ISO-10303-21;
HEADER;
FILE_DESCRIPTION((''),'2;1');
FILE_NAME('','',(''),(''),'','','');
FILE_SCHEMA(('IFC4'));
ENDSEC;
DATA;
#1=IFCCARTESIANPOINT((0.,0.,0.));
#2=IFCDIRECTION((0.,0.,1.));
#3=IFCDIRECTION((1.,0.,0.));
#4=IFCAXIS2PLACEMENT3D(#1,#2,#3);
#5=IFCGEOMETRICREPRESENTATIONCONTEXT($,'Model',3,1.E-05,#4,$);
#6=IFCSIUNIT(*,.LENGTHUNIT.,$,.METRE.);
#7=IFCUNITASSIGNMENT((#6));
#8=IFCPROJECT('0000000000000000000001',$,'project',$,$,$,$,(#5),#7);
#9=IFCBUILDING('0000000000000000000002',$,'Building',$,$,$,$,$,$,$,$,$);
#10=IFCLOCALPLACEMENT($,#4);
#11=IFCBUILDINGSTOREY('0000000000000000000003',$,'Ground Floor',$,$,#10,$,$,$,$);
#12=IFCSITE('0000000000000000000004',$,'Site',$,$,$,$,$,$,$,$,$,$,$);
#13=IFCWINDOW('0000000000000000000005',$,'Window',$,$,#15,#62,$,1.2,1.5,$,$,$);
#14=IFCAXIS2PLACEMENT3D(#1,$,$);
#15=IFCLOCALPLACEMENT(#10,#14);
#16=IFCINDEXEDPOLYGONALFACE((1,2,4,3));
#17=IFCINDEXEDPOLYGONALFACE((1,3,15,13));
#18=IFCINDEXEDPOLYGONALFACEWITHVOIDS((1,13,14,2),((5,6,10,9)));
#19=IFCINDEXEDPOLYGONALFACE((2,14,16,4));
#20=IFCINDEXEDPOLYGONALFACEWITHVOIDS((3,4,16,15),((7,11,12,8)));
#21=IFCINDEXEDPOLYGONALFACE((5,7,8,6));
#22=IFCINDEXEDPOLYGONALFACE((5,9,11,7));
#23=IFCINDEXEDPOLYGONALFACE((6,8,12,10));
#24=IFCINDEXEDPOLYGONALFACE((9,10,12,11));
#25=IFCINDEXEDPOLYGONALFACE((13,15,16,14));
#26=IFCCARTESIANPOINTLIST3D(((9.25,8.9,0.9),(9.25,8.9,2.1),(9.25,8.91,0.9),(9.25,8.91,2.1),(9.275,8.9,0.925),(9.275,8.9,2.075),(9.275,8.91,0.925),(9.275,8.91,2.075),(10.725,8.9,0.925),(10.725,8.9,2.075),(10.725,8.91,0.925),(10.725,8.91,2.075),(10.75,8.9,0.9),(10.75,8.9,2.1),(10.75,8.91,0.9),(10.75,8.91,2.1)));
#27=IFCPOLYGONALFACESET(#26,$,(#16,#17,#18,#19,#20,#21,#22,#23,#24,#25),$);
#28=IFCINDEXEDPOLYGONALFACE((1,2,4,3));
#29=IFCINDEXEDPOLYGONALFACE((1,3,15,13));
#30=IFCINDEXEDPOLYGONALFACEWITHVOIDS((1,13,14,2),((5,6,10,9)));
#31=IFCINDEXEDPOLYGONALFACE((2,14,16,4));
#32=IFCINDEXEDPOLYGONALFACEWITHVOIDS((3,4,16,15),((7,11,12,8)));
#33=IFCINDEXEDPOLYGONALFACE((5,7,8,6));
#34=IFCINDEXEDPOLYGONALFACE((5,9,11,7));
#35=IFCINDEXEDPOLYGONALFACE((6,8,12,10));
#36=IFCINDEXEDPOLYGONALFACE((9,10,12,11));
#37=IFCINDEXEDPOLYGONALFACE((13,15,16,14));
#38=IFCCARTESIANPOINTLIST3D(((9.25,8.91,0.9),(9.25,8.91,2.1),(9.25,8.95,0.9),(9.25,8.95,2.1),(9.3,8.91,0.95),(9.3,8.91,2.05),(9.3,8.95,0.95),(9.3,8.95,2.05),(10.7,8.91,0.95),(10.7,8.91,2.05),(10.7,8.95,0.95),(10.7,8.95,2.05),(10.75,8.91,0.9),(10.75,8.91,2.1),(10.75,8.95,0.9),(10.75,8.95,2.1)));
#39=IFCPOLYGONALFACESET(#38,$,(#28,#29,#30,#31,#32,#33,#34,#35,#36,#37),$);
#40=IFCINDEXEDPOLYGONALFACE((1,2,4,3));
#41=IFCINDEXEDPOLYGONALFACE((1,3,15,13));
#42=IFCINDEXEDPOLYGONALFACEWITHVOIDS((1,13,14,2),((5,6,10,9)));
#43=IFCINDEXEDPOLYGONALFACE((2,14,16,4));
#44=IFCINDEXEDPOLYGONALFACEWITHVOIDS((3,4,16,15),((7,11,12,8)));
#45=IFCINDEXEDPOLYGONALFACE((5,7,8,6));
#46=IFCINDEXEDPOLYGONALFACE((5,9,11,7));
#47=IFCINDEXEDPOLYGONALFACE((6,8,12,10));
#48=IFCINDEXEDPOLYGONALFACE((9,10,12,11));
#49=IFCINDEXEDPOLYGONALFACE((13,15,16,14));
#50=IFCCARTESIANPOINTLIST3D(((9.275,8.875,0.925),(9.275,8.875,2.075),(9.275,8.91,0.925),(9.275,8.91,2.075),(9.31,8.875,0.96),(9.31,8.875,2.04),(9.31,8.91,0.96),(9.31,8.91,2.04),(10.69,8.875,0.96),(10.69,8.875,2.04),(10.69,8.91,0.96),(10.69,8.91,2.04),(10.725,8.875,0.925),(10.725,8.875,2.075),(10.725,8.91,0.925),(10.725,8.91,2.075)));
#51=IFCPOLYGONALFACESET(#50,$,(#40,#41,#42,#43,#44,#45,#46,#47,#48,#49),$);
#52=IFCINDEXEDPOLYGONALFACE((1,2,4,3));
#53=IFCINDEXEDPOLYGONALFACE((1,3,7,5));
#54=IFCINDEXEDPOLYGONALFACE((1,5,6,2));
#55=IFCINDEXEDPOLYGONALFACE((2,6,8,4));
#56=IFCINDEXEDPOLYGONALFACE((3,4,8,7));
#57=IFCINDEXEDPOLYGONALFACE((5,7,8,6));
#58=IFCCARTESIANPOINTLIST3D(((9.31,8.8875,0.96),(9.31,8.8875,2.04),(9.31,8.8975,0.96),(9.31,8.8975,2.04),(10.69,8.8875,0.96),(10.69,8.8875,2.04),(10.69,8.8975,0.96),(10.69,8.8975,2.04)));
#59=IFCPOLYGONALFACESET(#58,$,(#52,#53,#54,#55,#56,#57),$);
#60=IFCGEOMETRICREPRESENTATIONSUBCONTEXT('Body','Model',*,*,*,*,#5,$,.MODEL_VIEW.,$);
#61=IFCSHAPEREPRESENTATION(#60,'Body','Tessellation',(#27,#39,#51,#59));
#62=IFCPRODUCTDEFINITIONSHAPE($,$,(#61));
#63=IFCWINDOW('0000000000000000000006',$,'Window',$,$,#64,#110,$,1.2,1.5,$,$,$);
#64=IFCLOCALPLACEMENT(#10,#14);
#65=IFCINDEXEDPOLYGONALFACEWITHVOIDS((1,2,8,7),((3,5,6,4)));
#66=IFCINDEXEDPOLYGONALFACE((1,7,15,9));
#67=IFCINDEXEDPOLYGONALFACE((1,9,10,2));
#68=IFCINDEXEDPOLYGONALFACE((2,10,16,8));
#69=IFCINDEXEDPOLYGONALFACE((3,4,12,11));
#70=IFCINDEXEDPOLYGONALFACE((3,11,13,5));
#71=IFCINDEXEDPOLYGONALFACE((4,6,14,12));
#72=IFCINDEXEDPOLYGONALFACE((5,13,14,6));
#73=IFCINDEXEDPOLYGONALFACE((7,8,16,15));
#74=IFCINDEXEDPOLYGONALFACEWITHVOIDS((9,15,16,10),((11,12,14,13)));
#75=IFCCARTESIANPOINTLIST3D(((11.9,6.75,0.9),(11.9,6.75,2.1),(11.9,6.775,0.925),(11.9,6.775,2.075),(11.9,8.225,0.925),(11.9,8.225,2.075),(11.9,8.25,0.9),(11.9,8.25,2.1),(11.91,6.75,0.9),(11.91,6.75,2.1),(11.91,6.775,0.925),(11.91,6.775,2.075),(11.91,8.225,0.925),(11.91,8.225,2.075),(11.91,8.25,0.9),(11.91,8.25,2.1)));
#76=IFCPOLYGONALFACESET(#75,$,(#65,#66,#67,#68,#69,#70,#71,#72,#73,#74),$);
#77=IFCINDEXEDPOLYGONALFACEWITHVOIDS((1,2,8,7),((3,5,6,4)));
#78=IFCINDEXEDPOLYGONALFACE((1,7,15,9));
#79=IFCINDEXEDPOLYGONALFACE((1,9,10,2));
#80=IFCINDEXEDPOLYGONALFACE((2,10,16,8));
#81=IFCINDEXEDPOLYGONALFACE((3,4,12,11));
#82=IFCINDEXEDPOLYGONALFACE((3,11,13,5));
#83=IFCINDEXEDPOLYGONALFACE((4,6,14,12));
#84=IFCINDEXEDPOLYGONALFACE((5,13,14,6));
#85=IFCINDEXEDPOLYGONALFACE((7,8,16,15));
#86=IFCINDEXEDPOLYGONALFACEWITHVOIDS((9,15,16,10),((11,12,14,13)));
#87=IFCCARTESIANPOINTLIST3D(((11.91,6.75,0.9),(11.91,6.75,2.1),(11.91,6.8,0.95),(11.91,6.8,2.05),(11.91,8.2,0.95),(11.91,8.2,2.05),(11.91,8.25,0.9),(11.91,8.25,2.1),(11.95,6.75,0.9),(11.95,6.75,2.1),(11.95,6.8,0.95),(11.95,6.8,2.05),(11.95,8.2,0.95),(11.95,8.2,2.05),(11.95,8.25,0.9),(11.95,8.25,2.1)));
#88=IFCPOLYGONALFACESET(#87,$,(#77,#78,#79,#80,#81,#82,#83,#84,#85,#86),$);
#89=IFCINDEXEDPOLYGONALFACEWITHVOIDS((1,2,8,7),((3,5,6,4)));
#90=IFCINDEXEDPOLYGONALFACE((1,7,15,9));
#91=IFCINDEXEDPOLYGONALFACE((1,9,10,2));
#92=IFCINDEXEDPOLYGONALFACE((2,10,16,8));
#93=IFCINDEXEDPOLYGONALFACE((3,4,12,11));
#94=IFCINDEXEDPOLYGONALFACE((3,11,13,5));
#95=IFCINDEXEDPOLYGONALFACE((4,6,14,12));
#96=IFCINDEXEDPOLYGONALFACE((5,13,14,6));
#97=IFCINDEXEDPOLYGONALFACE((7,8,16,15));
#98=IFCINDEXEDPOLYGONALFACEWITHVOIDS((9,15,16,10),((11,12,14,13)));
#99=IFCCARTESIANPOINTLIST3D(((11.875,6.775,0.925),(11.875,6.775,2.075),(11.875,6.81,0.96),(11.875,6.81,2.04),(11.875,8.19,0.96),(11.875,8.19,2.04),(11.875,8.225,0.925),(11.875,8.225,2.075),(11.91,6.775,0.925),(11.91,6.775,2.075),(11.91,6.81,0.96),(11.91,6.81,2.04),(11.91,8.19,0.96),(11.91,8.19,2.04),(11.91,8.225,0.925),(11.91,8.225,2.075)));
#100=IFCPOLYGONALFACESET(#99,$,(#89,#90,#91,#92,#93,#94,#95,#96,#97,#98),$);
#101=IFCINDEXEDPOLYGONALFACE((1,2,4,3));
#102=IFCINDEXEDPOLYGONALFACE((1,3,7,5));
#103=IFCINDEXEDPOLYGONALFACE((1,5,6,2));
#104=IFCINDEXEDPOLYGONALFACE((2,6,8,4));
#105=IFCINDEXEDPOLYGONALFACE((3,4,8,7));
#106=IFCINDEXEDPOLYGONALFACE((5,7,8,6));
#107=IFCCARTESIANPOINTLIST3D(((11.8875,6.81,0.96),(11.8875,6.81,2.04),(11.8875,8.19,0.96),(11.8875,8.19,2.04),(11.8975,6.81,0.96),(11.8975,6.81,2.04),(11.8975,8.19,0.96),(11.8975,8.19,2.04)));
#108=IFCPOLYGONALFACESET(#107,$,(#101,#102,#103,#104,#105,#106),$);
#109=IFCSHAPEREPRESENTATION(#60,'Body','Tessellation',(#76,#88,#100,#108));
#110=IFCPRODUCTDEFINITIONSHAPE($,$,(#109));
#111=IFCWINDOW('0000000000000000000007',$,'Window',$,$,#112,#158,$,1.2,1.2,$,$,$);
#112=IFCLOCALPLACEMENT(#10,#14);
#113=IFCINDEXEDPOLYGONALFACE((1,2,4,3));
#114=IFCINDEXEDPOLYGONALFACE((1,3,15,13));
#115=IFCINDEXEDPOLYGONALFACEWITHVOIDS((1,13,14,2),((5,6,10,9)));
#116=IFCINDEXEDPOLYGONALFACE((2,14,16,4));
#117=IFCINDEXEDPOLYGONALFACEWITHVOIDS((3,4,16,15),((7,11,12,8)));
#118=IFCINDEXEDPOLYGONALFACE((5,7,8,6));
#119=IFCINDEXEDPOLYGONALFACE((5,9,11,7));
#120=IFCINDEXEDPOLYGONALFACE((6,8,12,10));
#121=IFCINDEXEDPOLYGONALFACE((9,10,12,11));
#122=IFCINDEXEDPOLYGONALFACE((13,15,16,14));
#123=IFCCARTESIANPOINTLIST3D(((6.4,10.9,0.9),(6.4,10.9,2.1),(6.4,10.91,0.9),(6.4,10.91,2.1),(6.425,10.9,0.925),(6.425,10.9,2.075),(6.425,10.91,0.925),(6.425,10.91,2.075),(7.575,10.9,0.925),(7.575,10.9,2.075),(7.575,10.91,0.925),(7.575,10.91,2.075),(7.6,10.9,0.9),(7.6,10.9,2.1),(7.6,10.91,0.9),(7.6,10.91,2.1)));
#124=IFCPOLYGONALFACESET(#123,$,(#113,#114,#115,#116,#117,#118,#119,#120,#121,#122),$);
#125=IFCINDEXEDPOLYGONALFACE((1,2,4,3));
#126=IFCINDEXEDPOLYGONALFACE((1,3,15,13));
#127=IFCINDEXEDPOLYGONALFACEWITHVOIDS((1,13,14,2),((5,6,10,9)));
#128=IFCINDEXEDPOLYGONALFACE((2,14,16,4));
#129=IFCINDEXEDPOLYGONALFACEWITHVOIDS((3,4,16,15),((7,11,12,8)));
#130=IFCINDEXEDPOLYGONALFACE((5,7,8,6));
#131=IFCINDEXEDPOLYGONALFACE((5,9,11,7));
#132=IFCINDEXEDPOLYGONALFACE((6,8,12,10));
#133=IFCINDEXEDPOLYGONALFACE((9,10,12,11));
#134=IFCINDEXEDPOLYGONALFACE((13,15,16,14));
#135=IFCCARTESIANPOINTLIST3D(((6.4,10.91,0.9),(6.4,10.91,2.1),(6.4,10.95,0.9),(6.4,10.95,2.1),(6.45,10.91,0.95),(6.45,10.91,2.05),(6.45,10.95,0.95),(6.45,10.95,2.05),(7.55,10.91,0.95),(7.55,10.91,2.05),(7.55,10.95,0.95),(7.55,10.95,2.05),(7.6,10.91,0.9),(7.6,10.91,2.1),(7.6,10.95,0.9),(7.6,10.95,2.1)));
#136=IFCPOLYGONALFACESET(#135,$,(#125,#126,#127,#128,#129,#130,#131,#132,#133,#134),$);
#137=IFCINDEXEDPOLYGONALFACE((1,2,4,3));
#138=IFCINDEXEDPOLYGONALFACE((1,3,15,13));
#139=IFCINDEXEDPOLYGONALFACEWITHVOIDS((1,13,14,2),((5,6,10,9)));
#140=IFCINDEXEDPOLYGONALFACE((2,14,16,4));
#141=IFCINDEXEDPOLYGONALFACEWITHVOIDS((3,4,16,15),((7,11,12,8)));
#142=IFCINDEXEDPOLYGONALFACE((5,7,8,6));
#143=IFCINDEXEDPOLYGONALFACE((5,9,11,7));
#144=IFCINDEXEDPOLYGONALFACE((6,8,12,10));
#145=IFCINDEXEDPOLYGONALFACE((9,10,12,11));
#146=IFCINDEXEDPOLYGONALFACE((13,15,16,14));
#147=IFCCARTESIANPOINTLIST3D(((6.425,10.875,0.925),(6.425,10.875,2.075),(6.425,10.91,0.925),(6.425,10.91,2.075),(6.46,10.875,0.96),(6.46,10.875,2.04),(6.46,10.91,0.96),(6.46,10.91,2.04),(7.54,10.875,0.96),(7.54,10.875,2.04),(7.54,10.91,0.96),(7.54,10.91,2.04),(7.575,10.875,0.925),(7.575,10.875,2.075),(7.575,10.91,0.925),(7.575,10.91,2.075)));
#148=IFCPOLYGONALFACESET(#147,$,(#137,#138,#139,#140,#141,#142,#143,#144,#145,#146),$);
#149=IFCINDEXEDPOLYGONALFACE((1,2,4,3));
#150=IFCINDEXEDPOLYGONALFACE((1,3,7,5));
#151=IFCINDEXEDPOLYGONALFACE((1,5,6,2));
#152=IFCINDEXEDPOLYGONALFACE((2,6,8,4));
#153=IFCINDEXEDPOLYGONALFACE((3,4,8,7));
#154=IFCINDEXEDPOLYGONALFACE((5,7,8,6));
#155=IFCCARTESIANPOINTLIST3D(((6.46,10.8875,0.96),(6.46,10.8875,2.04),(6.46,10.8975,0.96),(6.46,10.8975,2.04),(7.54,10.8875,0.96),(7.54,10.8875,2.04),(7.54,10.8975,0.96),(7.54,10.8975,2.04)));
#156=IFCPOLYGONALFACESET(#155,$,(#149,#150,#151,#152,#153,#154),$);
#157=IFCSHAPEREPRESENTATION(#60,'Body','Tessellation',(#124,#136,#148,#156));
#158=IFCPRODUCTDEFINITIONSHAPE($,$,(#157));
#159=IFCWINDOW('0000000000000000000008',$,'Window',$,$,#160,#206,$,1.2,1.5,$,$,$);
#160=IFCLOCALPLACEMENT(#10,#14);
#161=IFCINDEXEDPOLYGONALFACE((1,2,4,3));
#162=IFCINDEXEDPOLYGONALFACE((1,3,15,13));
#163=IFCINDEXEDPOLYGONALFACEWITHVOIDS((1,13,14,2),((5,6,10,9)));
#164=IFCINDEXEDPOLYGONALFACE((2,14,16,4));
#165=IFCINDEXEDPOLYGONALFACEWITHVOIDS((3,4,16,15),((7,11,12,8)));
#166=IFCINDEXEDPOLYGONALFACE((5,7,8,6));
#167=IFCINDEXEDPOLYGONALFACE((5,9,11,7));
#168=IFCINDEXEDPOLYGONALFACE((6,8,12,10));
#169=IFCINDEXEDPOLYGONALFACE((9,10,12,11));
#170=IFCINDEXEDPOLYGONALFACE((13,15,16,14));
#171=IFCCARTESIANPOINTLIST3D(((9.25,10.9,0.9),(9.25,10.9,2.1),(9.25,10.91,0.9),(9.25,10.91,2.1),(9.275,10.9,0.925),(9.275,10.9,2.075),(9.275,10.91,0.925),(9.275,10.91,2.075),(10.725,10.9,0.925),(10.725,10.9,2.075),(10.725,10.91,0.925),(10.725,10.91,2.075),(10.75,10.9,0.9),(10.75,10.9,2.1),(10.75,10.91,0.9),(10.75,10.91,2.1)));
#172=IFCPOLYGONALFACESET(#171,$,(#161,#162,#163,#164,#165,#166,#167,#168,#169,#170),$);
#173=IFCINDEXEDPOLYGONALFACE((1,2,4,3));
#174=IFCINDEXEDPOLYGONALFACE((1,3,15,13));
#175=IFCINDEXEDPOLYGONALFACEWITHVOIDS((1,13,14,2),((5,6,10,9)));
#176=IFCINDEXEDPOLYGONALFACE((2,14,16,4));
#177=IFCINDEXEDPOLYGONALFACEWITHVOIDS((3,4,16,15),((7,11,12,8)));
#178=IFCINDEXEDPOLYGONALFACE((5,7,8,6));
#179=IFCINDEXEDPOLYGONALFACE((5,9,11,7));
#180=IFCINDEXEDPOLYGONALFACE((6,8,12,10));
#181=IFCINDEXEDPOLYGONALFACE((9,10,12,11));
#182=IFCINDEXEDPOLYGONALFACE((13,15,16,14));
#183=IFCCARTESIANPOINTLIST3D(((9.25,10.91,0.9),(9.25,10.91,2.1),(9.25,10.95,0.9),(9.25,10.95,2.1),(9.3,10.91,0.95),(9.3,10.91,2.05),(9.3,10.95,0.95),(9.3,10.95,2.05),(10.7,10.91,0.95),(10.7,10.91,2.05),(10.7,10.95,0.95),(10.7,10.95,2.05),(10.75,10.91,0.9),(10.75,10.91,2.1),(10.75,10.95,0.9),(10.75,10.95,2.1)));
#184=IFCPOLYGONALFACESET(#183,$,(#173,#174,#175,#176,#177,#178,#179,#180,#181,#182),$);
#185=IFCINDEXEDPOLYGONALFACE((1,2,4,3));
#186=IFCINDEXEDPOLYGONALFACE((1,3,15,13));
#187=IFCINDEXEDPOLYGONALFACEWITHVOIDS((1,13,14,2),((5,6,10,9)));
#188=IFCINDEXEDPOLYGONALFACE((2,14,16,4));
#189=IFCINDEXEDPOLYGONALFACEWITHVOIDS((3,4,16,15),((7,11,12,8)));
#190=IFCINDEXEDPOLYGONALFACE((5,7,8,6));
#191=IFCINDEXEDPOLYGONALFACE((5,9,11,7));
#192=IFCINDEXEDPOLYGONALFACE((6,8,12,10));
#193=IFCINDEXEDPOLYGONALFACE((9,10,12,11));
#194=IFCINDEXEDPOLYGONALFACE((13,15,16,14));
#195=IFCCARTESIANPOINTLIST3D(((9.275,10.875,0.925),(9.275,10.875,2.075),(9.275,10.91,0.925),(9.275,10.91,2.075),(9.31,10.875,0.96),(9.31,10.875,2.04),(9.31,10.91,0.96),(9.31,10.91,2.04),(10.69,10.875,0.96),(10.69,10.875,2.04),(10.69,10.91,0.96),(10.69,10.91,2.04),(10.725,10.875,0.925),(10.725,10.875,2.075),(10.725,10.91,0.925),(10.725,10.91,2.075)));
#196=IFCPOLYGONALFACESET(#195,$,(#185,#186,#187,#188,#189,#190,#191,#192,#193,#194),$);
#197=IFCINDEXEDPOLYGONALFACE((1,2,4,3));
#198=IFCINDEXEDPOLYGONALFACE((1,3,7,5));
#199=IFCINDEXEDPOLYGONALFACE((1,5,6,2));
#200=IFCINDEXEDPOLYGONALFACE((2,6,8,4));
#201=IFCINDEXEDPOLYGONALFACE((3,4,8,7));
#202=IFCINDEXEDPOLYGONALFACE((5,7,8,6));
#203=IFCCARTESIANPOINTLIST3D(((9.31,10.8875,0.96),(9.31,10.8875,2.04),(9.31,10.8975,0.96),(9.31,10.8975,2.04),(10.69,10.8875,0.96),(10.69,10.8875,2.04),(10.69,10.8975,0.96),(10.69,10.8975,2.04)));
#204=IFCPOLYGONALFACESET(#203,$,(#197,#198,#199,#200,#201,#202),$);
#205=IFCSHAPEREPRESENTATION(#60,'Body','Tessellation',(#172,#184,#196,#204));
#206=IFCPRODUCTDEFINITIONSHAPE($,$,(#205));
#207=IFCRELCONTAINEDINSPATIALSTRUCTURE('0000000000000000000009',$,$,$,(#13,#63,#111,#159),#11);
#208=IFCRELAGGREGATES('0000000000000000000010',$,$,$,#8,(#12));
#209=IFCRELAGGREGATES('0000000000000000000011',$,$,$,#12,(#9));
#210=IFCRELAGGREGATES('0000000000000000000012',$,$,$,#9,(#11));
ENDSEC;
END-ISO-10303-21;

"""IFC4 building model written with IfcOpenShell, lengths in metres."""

from ifc_helpers import new_model, si_unit, frame, origin_with_axes, place, context, subcontext, project, spatial, line, indexed_curve, outline, extrude, element, save


model = new_model("IFC4")

# Units and contexts
model_context = context("Model", 3, precision=1e-05, world=origin_with_axes())
body_context = subcontext(model_context, "Body", "Model", "MODEL_VIEW")
ifc_project = project(units=[si_unit("LENGTHUNIT", "METRE")], contexts=[model_context])

# Site, building, storey
site = spatial("IfcSite", under=ifc_project, Name="Site")
building = spatial("IfcBuilding", under=site, Name="Building")
storey_placement = place(None, origin_with_axes())
storey = spatial("IfcBuildingStorey", under=building, at=storey_placement, Name="Ground Floor")

# Windows
for number, where, z_axis, x_axis, name in (
    (1, (10.75, 9.0, 0.9), (0.0, 0.0, 1.0), (-1.0, 0.0, 0.0), "Window"),
    (2, (12.0, 6.75, 0.9), (0.0, 0.0, 1.0), (0.0, 1.0, 0.0), "Window"),
):
    element("IfcWindow", number, at=place(storey_placement, frame(where, z_axis=z_axis, x_axis=x_axis)), inside=storey, Name=name, OverallHeight=1.2, OverallWidth=1.5, context=body_context, shape_type="SweptSolid", body=[
        extrude(outline(indexed_curve([(0.0, 0.0), (1.5, 0.0), (1.5, 1.2), (0.0, 1.2)], segments=[line(1, 2, 3, 4, 1)]), holes=[indexed_curve([(0.025, 0.025), (1.475, 0.025), (1.475, 1.175), (0.025, 1.175)], segments=[line(1, 2, 3, 4, 1)])]), frame((0.0, 0.09, 0.0), z_axis=(0.0, -1.0, 0.0), x_axis=(1.0, 0.0, 0.0)), (0.0, 0.0, -1.0), 0.01),
        extrude(outline(indexed_curve([(0.0, 0.0), (1.5, 0.0), (1.5, 1.2), (0.0, 1.2)], segments=[line(1, 2, 3, 4, 1)]), holes=[indexed_curve([(0.05, 0.05), (1.45, 0.05), (1.45, 1.15), (0.05, 1.15)], segments=[line(1, 2, 3, 4, 1)])]), frame((0.0, 0.05, 0.0), z_axis=(0.0, -1.0, 0.0), x_axis=(1.0, 0.0, 0.0)), (0.0, 0.0, -1.0), 0.04),
        extrude(outline(indexed_curve([(0.0, 0.0), (1.45, 0.0), (1.45, 1.15), (0.0, 1.15)], segments=[line(1, 2, 3, 4, 1)]), holes=[indexed_curve([(0.035, 0.035), (1.415, 0.035), (1.415, 1.115), (0.035, 1.115)], segments=[line(1, 2, 3, 4, 1)])]), frame((0.025, 0.09, 0.025), z_axis=(0.0, -1.0, 0.0), x_axis=(1.0, 0.0, 0.0)), (0.0, 0.0, -1.0), 0.035),
        extrude(outline(indexed_curve([(0.035, 0.035), (1.415, 0.035), (1.415, 1.115), (0.035, 1.115)], segments=[line(1, 2, 3, 4, 1)])), frame((0.025, 0.1025, 0.025), z_axis=(0.0, -1.0, 0.0), x_axis=(1.0, 0.0, 0.0)), (0.0, 0.0, -1.0), 0.01),
    ])
window_1_placement = place(storey_placement, frame((7.6, 11.0, 0.9), z_axis=(0.0, 0.0, 1.0), x_axis=(-1.0, 0.0, 0.0)))
element("IfcWindow", 3, at=window_1_placement, inside=storey, Name="Window", OverallHeight=1.2, OverallWidth=1.2, context=body_context, shape_type="SweptSolid", body=[
    extrude(outline(indexed_curve([(0.0, 0.0), (1.2, 0.0), (1.2, 1.2), (0.0, 1.2)], segments=[line(1, 2, 3, 4, 1)]), holes=[indexed_curve([(0.025, 0.025), (1.175, 0.025), (1.175, 1.175), (0.025, 1.175)], segments=[line(1, 2, 3, 4, 1)])]), frame((0.0, 0.09, 0.0), z_axis=(0.0, -1.0, 0.0), x_axis=(1.0, 0.0, 0.0)), (0.0, 0.0, -1.0), 0.01),
    extrude(outline(indexed_curve([(0.0, 0.0), (1.2, 0.0), (1.2, 1.2), (0.0, 1.2)], segments=[line(1, 2, 3, 4, 1)]), holes=[indexed_curve([(0.05, 0.05), (1.15, 0.05), (1.15, 1.15), (0.05, 1.15)], segments=[line(1, 2, 3, 4, 1)])]), frame((0.0, 0.05, 0.0), z_axis=(0.0, -1.0, 0.0), x_axis=(1.0, 0.0, 0.0)), (0.0, 0.0, -1.0), 0.04),
    extrude(outline(indexed_curve([(0.0, 0.0), (1.15, 0.0), (1.15, 1.15), (0.0, 1.15)], segments=[line(1, 2, 3, 4, 1)]), holes=[indexed_curve([(0.035, 0.035), (1.115, 0.035), (1.115, 1.115), (0.035, 1.115)], segments=[line(1, 2, 3, 4, 1)])]), frame((0.025, 0.09, 0.025), z_axis=(0.0, -1.0, 0.0), x_axis=(1.0, 0.0, 0.0)), (0.0, 0.0, -1.0), 0.035),
    extrude(outline(indexed_curve([(0.035, 0.035), (1.115, 0.035), (1.115, 1.115), (0.035, 1.115)], segments=[line(1, 2, 3, 4, 1)])), frame((0.025, 0.1025, 0.025), z_axis=(0.0, -1.0, 0.0), x_axis=(1.0, 0.0, 0.0)), (0.0, 0.0, -1.0), 0.01),
])
window_2_placement = place(storey_placement, frame((10.75, 11.0, 0.9), z_axis=(0.0, 0.0, 1.0), x_axis=(-1.0, 0.0, 0.0)))
element("IfcWindow", 4, at=window_2_placement, inside=storey, Name="Window", OverallHeight=1.2, OverallWidth=1.5, context=body_context, shape_type="SweptSolid", body=[
    extrude(outline(indexed_curve([(0.0, 0.0), (1.5, 0.0), (1.5, 1.2), (0.0, 1.2)], segments=[line(1, 2, 3, 4, 1)]), holes=[indexed_curve([(0.025, 0.025), (1.475, 0.025), (1.475, 1.175), (0.025, 1.175)], segments=[line(1, 2, 3, 4, 1)])]), frame((0.0, 0.09, 0.0), z_axis=(0.0, -1.0, 0.0), x_axis=(1.0, 0.0, 0.0)), (0.0, 0.0, -1.0), 0.01),
    extrude(outline(indexed_curve([(0.0, 0.0), (1.5, 0.0), (1.5, 1.2), (0.0, 1.2)], segments=[line(1, 2, 3, 4, 1)]), holes=[indexed_curve([(0.05, 0.05), (1.45, 0.05), (1.45, 1.15), (0.05, 1.15)], segments=[line(1, 2, 3, 4, 1)])]), frame((0.0, 0.05, 0.0), z_axis=(0.0, -1.0, 0.0), x_axis=(1.0, 0.0, 0.0)), (0.0, 0.0, -1.0), 0.04),
    extrude(outline(indexed_curve([(0.0, 0.0), (1.45, 0.0), (1.45, 1.15), (0.0, 1.15)], segments=[line(1, 2, 3, 4, 1)]), holes=[indexed_curve([(0.035, 0.035), (1.415, 0.035), (1.415, 1.115), (0.035, 1.115)], segments=[line(1, 2, 3, 4, 1)])]), frame((0.025, 0.09, 0.025), z_axis=(0.0, -1.0, 0.0), x_axis=(1.0, 0.0, 0.0)), (0.0, 0.0, -1.0), 0.035),
    extrude(outline(indexed_curve([(0.035, 0.035), (1.415, 0.035), (1.415, 1.115), (0.035, 1.115)], segments=[line(1, 2, 3, 4, 1)])), frame((0.025, 0.1025, 0.025), z_axis=(0.0, -1.0, 0.0), x_axis=(1.0, 0.0, 0.0)), (0.0, 0.0, -1.0), 0.01),
])

save(model, "model.ifc")
